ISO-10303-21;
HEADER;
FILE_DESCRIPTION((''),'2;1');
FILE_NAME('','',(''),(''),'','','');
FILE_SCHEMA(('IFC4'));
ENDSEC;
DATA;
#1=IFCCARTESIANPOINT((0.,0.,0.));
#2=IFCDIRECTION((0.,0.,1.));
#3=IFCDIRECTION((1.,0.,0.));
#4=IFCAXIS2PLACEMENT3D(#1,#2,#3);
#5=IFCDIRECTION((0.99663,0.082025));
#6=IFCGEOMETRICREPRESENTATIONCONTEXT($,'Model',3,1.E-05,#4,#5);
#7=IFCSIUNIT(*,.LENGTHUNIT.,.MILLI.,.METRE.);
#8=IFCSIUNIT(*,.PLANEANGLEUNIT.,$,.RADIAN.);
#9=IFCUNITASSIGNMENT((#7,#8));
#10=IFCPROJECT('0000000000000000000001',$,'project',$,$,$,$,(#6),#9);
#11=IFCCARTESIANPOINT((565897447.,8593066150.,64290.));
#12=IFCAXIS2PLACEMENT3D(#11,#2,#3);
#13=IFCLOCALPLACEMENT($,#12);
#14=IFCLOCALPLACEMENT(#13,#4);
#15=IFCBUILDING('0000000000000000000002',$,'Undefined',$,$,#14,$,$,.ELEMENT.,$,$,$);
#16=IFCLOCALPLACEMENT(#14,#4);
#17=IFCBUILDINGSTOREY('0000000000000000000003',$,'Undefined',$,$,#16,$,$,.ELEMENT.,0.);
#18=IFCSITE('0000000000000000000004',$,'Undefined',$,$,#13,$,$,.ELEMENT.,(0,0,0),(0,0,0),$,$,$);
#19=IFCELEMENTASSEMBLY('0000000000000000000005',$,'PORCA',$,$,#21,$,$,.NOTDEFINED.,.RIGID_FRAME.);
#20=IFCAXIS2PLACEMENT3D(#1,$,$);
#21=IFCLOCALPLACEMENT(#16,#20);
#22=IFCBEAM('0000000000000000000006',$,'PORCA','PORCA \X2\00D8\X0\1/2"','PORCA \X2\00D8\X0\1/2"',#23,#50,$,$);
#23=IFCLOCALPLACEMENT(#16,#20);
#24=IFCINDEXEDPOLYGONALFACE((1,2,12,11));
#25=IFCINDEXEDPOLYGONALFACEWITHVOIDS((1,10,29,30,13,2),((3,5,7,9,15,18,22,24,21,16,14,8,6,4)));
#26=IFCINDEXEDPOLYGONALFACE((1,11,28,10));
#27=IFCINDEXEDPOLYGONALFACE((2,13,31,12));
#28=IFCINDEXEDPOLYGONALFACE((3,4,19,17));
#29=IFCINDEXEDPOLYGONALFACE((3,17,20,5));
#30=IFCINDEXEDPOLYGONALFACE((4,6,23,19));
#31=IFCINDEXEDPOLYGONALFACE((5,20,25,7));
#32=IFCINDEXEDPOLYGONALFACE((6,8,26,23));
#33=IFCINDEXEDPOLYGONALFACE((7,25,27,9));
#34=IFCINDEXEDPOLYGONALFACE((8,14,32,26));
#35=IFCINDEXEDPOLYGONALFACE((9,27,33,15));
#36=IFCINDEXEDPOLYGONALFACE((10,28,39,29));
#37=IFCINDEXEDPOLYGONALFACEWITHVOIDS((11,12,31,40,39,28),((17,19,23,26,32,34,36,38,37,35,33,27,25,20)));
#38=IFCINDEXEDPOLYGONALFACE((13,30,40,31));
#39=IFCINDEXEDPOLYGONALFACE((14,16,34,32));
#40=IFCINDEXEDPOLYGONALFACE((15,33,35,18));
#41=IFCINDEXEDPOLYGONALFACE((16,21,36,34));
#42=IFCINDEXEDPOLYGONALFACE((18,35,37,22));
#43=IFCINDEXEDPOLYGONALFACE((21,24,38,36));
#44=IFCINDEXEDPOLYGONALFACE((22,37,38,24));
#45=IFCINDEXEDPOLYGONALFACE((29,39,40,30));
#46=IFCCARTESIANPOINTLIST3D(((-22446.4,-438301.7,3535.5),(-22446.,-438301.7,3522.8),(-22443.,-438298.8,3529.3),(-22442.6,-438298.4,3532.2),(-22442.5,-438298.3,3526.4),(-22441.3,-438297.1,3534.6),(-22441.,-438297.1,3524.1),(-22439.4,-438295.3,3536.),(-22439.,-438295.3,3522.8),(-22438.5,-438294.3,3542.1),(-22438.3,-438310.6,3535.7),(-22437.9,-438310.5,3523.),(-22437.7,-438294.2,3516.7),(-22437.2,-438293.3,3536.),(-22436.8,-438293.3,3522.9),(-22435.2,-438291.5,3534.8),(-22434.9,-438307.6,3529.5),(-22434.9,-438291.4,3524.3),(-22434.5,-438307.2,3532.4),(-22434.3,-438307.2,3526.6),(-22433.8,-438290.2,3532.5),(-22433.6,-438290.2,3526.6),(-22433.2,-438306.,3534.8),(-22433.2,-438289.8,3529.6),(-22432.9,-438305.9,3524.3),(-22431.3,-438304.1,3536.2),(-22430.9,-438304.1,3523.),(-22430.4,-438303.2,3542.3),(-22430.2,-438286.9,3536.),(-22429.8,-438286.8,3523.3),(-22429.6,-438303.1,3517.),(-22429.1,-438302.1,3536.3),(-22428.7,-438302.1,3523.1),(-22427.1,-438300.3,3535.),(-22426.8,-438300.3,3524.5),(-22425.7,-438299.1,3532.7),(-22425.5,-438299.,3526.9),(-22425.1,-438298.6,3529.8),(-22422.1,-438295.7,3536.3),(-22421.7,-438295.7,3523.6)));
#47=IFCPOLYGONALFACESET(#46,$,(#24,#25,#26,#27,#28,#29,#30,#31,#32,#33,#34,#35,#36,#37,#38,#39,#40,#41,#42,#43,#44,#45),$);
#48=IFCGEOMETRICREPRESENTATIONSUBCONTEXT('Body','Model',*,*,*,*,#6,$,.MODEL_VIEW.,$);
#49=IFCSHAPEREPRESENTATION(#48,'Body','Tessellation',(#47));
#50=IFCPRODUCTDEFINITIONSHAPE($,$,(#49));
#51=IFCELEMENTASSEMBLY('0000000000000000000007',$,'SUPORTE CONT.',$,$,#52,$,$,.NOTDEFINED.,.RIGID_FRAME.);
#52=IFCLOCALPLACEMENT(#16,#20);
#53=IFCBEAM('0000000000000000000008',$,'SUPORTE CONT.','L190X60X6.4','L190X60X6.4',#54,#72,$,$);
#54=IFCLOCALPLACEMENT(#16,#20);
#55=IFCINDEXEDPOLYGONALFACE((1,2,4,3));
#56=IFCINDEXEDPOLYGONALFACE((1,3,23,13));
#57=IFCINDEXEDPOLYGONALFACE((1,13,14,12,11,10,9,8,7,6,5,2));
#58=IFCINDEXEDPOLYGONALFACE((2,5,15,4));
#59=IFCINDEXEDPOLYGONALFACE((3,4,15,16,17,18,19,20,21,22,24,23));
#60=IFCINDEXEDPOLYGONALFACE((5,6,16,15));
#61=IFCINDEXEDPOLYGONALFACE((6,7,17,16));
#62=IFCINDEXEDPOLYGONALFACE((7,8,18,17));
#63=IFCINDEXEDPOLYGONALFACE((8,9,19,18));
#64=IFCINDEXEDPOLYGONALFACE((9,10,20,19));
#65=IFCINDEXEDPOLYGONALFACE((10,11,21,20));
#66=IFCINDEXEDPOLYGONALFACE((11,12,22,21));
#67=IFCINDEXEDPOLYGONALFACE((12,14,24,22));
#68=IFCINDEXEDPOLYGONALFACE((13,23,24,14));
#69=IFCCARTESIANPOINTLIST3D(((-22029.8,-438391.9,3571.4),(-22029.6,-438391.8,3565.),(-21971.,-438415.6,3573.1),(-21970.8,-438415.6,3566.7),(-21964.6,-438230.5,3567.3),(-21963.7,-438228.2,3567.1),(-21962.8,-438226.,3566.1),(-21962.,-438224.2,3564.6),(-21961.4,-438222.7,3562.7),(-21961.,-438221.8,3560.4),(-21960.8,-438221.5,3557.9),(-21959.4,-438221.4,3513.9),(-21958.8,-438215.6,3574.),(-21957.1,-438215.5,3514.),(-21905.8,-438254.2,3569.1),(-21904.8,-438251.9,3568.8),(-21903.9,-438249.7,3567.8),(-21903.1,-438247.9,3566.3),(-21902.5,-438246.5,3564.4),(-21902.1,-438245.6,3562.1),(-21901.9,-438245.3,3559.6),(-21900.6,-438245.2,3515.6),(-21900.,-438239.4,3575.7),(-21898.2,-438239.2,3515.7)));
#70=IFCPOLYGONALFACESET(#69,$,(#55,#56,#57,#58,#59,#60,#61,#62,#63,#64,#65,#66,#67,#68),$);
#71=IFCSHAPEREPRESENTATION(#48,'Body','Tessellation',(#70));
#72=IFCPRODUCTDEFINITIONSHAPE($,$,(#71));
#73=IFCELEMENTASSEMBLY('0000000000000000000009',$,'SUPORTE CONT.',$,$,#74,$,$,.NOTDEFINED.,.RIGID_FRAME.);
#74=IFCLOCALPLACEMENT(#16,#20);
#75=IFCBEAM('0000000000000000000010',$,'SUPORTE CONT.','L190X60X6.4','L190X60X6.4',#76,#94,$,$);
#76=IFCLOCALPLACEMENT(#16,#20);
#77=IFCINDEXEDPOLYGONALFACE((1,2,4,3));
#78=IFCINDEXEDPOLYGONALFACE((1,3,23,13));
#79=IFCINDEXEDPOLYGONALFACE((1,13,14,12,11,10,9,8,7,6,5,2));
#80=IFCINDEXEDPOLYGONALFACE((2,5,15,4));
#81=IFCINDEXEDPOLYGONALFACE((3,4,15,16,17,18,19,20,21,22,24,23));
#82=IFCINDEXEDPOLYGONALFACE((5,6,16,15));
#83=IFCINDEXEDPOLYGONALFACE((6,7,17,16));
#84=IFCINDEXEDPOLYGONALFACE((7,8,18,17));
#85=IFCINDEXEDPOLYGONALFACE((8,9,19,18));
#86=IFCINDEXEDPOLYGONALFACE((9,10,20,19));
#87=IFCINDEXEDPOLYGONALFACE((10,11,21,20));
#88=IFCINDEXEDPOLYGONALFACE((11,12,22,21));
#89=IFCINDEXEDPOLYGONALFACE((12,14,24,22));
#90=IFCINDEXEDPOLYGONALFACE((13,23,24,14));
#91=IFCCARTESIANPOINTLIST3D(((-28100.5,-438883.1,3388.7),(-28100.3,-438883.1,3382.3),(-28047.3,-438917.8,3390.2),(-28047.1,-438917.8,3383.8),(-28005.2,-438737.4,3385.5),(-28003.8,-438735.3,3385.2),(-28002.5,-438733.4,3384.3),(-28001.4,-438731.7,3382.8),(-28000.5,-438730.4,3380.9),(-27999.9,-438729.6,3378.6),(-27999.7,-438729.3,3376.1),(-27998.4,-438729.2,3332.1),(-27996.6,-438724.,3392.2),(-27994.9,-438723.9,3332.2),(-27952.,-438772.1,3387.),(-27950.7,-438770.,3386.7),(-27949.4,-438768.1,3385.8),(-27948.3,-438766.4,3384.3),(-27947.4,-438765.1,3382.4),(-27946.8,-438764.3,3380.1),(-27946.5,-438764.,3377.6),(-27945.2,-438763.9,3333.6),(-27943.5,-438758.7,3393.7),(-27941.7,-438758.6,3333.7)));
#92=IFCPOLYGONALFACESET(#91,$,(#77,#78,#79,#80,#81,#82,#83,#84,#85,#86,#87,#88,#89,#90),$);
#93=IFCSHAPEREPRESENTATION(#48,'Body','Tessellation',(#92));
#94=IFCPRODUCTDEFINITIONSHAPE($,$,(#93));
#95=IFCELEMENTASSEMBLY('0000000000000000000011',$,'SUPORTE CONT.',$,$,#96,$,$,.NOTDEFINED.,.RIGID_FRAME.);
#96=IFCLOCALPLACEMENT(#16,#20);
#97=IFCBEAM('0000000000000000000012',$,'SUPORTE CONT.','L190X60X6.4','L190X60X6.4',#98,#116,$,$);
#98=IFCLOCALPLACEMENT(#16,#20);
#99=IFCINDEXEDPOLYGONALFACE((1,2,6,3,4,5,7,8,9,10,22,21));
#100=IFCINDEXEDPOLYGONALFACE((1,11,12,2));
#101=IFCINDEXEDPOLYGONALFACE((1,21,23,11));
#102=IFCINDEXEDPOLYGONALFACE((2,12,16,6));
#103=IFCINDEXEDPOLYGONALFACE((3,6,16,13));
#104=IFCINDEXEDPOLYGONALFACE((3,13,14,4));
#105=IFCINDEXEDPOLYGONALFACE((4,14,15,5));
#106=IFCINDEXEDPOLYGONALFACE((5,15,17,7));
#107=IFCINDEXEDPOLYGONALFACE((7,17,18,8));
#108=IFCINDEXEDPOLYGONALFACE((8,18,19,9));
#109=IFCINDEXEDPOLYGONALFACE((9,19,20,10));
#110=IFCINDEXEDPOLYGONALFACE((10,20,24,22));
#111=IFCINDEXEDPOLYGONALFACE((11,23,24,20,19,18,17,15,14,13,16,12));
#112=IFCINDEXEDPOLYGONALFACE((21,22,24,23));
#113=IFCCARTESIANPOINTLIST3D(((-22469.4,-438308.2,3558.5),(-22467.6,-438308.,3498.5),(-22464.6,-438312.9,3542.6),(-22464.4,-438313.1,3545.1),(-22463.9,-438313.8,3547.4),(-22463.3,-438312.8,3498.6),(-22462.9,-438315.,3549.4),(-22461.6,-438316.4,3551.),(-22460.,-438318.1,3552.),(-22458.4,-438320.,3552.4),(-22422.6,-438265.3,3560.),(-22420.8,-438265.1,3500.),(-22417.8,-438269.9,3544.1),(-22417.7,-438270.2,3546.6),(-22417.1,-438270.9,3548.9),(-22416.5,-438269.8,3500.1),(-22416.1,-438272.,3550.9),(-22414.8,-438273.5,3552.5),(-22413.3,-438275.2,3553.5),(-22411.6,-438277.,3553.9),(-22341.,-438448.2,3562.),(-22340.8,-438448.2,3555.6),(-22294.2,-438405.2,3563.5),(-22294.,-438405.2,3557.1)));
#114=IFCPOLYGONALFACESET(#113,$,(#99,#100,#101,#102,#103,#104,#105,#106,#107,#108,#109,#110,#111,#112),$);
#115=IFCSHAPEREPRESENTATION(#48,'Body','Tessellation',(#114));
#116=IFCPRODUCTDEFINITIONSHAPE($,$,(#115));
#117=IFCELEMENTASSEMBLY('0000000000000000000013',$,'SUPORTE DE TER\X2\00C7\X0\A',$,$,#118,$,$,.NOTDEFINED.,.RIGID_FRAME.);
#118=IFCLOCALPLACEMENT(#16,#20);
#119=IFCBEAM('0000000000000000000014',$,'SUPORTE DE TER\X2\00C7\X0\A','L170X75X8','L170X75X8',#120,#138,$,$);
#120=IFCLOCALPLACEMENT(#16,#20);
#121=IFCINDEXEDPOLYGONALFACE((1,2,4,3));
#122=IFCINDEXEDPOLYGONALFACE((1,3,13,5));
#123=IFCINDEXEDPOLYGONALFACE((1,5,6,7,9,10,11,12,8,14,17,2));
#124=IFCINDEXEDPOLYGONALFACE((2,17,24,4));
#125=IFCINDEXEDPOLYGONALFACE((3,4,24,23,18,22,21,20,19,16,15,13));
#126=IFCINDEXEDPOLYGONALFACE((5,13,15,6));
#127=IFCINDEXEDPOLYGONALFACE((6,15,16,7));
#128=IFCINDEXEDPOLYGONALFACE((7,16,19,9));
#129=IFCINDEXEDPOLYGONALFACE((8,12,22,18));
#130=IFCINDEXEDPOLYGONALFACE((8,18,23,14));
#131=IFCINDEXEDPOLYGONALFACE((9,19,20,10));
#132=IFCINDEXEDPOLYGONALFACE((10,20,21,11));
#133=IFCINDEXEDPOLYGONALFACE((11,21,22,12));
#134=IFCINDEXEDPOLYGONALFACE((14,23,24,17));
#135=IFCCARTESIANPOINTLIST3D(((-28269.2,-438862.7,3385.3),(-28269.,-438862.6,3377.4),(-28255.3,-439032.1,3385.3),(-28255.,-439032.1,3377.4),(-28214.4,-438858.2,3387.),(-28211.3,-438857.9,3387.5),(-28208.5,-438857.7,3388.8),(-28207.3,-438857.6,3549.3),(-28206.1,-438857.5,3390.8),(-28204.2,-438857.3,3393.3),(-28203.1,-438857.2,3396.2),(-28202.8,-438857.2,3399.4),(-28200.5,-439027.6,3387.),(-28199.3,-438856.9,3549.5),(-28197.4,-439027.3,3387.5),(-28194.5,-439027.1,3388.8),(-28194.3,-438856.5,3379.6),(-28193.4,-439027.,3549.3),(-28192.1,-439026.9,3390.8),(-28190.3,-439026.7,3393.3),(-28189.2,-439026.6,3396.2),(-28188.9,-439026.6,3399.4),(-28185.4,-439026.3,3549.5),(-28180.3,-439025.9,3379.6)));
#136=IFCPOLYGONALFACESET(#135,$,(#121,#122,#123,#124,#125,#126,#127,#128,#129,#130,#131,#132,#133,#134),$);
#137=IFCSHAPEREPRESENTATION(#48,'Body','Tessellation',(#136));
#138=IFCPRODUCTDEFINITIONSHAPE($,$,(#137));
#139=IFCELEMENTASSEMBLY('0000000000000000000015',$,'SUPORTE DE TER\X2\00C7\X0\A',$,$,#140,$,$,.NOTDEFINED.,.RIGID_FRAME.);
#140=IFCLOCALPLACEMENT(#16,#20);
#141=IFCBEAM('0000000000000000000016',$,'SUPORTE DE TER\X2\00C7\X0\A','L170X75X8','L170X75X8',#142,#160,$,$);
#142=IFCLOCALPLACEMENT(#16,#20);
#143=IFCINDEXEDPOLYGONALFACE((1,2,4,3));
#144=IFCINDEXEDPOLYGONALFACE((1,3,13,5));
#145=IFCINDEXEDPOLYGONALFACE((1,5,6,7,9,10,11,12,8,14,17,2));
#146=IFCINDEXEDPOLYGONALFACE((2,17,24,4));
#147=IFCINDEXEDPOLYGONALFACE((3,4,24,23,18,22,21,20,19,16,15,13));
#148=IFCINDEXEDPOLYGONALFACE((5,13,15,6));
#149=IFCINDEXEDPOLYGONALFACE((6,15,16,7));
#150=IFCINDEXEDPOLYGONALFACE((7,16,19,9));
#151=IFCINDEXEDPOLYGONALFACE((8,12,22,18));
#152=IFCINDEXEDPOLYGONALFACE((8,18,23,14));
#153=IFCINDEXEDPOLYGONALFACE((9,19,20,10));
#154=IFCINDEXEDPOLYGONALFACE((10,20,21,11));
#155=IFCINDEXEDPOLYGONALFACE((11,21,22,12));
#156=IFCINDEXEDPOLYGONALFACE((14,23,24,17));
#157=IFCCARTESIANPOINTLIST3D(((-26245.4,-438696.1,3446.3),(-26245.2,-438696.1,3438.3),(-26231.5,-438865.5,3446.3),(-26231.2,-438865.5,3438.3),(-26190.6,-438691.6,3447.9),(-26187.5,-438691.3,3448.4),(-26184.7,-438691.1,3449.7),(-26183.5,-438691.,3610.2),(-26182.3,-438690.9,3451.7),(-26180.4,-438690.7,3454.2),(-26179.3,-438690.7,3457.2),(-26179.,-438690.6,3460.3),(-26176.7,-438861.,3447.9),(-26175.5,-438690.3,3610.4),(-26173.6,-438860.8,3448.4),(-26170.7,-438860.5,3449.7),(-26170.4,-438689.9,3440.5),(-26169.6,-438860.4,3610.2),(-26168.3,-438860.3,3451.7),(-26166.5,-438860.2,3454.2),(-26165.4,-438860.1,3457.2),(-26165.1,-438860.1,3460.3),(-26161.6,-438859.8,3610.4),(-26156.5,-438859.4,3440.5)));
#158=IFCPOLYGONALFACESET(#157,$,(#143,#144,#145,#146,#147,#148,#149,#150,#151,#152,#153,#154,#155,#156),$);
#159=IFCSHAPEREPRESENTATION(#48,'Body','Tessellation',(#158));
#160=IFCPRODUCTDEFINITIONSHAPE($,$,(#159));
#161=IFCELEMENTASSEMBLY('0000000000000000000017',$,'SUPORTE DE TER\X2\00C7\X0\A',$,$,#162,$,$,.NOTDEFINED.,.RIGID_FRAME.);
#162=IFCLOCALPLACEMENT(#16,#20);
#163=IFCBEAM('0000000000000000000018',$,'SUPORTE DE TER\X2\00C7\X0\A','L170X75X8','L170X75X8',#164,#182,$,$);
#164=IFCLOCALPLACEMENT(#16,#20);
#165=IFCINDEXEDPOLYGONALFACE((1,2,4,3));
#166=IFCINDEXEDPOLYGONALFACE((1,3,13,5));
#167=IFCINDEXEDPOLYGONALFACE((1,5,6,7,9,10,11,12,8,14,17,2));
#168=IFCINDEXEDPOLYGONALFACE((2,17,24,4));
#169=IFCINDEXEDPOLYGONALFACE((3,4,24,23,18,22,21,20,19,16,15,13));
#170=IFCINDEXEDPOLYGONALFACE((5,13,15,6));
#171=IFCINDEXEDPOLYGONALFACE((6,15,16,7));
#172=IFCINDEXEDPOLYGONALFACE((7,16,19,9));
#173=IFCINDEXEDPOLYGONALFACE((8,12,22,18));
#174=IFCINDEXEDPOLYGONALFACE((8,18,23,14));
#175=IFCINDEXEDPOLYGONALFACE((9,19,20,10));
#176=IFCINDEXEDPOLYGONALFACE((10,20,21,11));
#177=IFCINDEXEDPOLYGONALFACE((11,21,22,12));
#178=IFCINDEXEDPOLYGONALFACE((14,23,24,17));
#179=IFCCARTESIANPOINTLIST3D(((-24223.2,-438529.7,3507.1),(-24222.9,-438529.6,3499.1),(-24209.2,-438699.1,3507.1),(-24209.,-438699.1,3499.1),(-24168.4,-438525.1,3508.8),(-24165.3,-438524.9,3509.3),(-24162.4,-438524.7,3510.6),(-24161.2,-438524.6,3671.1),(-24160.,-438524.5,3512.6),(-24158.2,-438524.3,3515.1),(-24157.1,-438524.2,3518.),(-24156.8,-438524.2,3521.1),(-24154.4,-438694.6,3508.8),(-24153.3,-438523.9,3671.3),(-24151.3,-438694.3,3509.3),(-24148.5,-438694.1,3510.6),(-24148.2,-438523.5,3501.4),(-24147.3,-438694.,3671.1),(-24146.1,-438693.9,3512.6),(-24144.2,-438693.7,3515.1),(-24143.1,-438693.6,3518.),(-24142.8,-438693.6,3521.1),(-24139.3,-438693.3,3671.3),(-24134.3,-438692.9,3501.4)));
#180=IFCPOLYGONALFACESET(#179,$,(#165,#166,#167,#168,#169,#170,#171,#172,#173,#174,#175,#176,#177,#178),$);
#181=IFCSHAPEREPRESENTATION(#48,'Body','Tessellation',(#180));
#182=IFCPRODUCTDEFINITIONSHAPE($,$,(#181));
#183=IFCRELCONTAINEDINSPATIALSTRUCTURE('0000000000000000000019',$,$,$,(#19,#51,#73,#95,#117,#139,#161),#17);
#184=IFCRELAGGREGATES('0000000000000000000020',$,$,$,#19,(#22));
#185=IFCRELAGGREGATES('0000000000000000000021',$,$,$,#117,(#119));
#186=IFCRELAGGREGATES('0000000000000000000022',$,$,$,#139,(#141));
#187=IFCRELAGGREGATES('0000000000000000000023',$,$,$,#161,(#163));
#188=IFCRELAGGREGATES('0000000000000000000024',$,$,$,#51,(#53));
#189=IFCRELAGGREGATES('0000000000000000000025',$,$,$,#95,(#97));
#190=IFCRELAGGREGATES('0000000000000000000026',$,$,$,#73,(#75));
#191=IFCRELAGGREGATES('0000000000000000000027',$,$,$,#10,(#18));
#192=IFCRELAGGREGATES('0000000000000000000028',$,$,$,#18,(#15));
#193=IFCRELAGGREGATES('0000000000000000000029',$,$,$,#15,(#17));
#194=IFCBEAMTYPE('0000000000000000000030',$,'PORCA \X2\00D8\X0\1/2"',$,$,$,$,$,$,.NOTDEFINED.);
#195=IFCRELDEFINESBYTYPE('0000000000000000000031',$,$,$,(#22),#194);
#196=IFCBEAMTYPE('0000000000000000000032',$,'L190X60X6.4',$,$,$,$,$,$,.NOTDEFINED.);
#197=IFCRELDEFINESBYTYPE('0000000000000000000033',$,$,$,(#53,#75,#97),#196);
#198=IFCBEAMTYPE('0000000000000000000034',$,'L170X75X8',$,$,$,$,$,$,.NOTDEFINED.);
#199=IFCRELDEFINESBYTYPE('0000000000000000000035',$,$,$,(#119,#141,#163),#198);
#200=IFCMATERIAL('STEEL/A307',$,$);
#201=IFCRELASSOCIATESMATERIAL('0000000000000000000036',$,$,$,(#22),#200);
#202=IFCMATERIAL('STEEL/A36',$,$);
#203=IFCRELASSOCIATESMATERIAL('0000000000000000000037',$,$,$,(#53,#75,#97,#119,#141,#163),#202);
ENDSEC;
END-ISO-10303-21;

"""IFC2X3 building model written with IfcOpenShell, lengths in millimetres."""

from ifc_helpers import new_model, si_unit, direction, frame, origin_with_axes, origin_2d_with_axis, place, context, subcontext, project, spatial, polyline, l_section, outline, extrude, material, type_object, element, aggregate, save


model = new_model("IFC2X3")

# Units and contexts
model_context = context("Model", 3, precision=1e-05, world=origin_with_axes(), true_north=direction((0.99663, 0.082025)))
body_context = subcontext(model_context, "Body", "Model", "MODEL_VIEW")
ifc_project = project(units=[si_unit("LENGTHUNIT", "METRE", prefix="MILLI"), si_unit("PLANEANGLEUNIT", "RADIAN")], contexts=[model_context])

# Site, building, storey
site_placement = place(None, frame((565897447.0, 8593066150.0, 64290.0), z_axis=(0.0, 0.0, 1.0), x_axis=(1.0, 0.0, 0.0)))
site = spatial("IfcSite", under=ifc_project, at=site_placement, Name="Undefined", CompositionType="ELEMENT", RefLatitude=(0, 0, 0), RefLongitude=(0, 0, 0))
building_placement = place(site_placement, origin_with_axes())
building = spatial("IfcBuilding", under=site, at=building_placement, Name="Undefined", CompositionType="ELEMENT")
storey_placement = place(building_placement, origin_with_axes())
storey = spatial("IfcBuildingStorey", under=building, at=storey_placement, Name="Undefined", CompositionType="ELEMENT", Elevation=0.0)

# Element assemblies, beams
ifc_material_1 = material(Name="STEEL/A307")
beam_type_1 = type_object("IfcBeamType", Name="PORCA Ø1/2\"", PredefinedType="NOTDEFINED")
assembly_1_placement = place(storey_placement, origin_with_axes())
assembly_1 = element("IfcElementAssembly", 1, at=assembly_1_placement, inside=storey, Name="PORCA", AssemblyPlace="NOTDEFINED", PredefinedType="RIGID_FRAME")
beam_1_placement = place(assembly_1_placement, frame((-22430.0, -438303.1, 3529.6), z_axis=(0.736334, 0.676203, 0.02368), x_axis=(-0.675958, 0.736711, -0.018398)))
beam_1 = element("IfcBeam", 2, at=beam_1_placement, type_object=beam_type_1, material=ifc_material_1, Name="PORCA", Description="PORCA Ø1/2\"", ObjectType="PORCA Ø1/2\"", context=body_context, shape_type="SweptSolid", body=[
    extrude(outline(polyline([(-6.3, -11.0), (-12.7, 0.0), (-6.3, 11.0), (6.3, 11.0), (12.7, 0.0), (6.3, -11.0), (-6.3, -11.0)]), holes=[polyline([(5.3, 4.2), (2.9, 6.0), (0.0, 6.7), (-2.9, 6.0), (-5.3, 4.2), (-6.6, 1.5), (-6.6, -1.5), (-5.3, -4.2), (-2.9, -6.0), (0.0, -6.7), (2.9, -6.0), (5.3, -4.2), (6.6, -1.5), (6.6, 1.5), (5.3, 4.2)])]), frame((12.0, 0.0, 0.0), z_axis=(-1.0, 0.0, 0.0), x_axis=(0.0, -1.0, 0.0)), (0.0, 0.0, 1.0), 12.0),
])
aggregate(assembly_1, [beam_1])
assembly_2_placement = place(storey_placement, origin_with_axes())
assembly_2 = element("IfcElementAssembly", 3, at=assembly_2_placement, inside=storey, Name="SUPORTE CONT.", AssemblyPlace="NOTDEFINED", PredefinedType="RIGID_FRAME")
ifc_material_2 = material(Name="STEEL/A36")
beam_type_2 = type_object("IfcBeamType", Name="L190X60X6.4", PredefinedType="NOTDEFINED")
beam_2_placement = place(assembly_2_placement, frame((-21993.4, -438303.7, 3542.7), z_axis=(-0.373645, -0.927474, -0.013454), x_axis=(0.92709, -0.373879, 0.026799)))
beam_2 = element("IfcBeam", 4, at=beam_2_placement, type_object=beam_type_2, material=ifc_material_2, Name="SUPORTE CONT.", Description="L190X60X6.4", ObjectType="L190X60X6.4", context=body_context, shape_type="SweptSolid", body=[
    extrude(l_section(Depth=190.0, Width=60.0, Thickness=6.4, FilletRadius=9.6, at=origin_2d_with_axis()), frame((63.5, 0.0, 0.0), z_axis=(-1.0, 0.0, 0.0), x_axis=(0.0, -1.0, 0.0)), (0.0, 0.0, 1.0), 63.5),
])
assembly_3_placement = place(storey_placement, origin_with_axes())
assembly_3 = element("IfcElementAssembly", 5, at=assembly_3_placement, inside=storey, Name="SUPORTE CONT.", AssemblyPlace="NOTDEFINED", PredefinedType="RIGID_FRAME")
beam_3_placement = place(assembly_3_placement, frame((-28047.7, -438803.5, 3360.5), z_axis=(-0.546411, -0.837315, -0.018398), x_axis=(0.836984, -0.546715, 0.02368)))
beam_3 = element("IfcBeam", 6, at=beam_3_placement, type_object=beam_type_2, material=ifc_material_2, Name="SUPORTE CONT.", Description="L190X60X6.4", ObjectType="L190X60X6.4", context=body_context, shape_type="SweptSolid", body=[
    extrude(l_section(Depth=190.0, Width=60.0, Thickness=6.4, FilletRadius=9.6, at=origin_2d_with_axis()), frame((63.5, 0.0, 0.0), z_axis=(-1.0, 0.0, 0.0), x_axis=(0.0, -1.0, 0.0)), (0.0, 0.0, 1.0), 63.5),
])
assembly_4_placement = place(storey_placement, origin_with_axes())
assembly_4 = element("IfcElementAssembly", 7, at=assembly_4_placement, inside=storey, Name="SUPORTE CONT.", AssemblyPlace="NOTDEFINED", PredefinedType="RIGID_FRAME")
beam_4_placement = place(assembly_4_placement, frame((-22404.3, -438378.1, 3530.2), z_axis=(0.675958, -0.736711, 0.018398), x_axis=(0.736334, 0.676203, 0.02368)))
beam_4 = element("IfcBeam", 8, at=beam_4_placement, type_object=beam_type_2, material=ifc_material_2, Name="SUPORTE CONT.", Description="L190X60X6.4", ObjectType="L190X60X6.4", context=body_context, shape_type="SweptSolid", body=[
    extrude(l_section(Depth=190.0, Width=60.0, Thickness=6.4, FilletRadius=9.6, at=origin_2d_with_axis()), frame((63.5, 0.0, 0.0), z_axis=(-1.0, 0.0, 0.0), x_axis=(0.0, -1.0, 0.0)), (0.0, 0.0, 1.0), 63.5),
])
assembly_5_placement = place(storey_placement, origin_with_axes())
assembly_5 = element("IfcElementAssembly", 9, at=assembly_5_placement, inside=storey, Name="SUPORTE DE TERÇA", AssemblyPlace="NOTDEFINED", PredefinedType="RIGID_FRAME")
beam_type_3 = type_object("IfcBeamType", Name="L170X75X8", PredefinedType="NOTDEFINED")
beam_5_placement = place(assembly_5_placement, frame((-28234.1, -438859.8, 3463.4), z_axis=(-0.029885, -0.00246, 0.99955), x_axis=(0.082025, -0.99663, 0.0)))
beam_5 = element("IfcBeam", 10, at=beam_5_placement, type_object=beam_type_3, material=ifc_material_2, Name="SUPORTE DE TERÇA", Description="L170X75X8", ObjectType="L170X75X8", context=body_context, shape_type="SweptSolid", body=[
    extrude(l_section(Depth=170.0, Width=75.0, Thickness=8.0, FilletRadius=12.0, at=origin_2d_with_axis()), frame((170.0, 0.0, 0.0), z_axis=(-1.0, 0.0, 0.0), x_axis=(0.0, -1.0, 0.0)), (0.0, 0.0, 1.0), 170.0),
])
aggregate(assembly_5, [beam_5])
assembly_6_placement = place(storey_placement, origin_with_axes())
assembly_6 = element("IfcElementAssembly", 11, at=assembly_6_placement, inside=storey, Name="SUPORTE DE TERÇA", AssemblyPlace="NOTDEFINED", PredefinedType="RIGID_FRAME")
beam_6_placement = place(assembly_6_placement, frame((-26210.3, -438693.2, 3524.4), z_axis=(-0.029885, -0.00246, 0.99955), x_axis=(0.082025, -0.99663, 0.0)))
beam_6 = element("IfcBeam", 12, at=beam_6_placement, type_object=beam_type_3, material=ifc_material_2, Name="SUPORTE DE TERÇA", Description="L170X75X8", ObjectType="L170X75X8", context=body_context, shape_type="SweptSolid", body=[
    extrude(l_section(Depth=170.0, Width=75.0, Thickness=8.0, FilletRadius=12.0, at=origin_2d_with_axis()), frame((170.0, 0.0, 0.0), z_axis=(-1.0, 0.0, 0.0), x_axis=(0.0, -1.0, 0.0)), (0.0, 0.0, 1.0), 170.0),
])
aggregate(assembly_6, [beam_6])
assembly_7_placement = place(storey_placement, origin_with_axes())
assembly_7 = element("IfcElementAssembly", 13, at=assembly_7_placement, inside=storey, Name="SUPORTE DE TERÇA", AssemblyPlace="NOTDEFINED", PredefinedType="RIGID_FRAME")
beam_7_placement = place(assembly_7_placement, frame((-24188.1, -438526.8, 3585.2), z_axis=(-0.029885, -0.00246, 0.99955), x_axis=(0.082025, -0.99663, 0.0)))
beam_7 = element("IfcBeam", 14, at=beam_7_placement, type_object=beam_type_3, material=ifc_material_2, Name="SUPORTE DE TERÇA", Description="L170X75X8", ObjectType="L170X75X8", context=body_context, shape_type="SweptSolid", body=[
    extrude(l_section(Depth=170.0, Width=75.0, Thickness=8.0, FilletRadius=12.0, at=origin_2d_with_axis()), frame((170.0, 0.0, 0.0), z_axis=(-1.0, 0.0, 0.0), x_axis=(0.0, -1.0, 0.0)), (0.0, 0.0, 1.0), 170.0),
])
aggregate(assembly_7, [beam_7])

aggregate(assembly_2, [beam_2])
aggregate(assembly_4, [beam_4])
aggregate(assembly_3, [beam_3])

save(model, "model.ifc")
